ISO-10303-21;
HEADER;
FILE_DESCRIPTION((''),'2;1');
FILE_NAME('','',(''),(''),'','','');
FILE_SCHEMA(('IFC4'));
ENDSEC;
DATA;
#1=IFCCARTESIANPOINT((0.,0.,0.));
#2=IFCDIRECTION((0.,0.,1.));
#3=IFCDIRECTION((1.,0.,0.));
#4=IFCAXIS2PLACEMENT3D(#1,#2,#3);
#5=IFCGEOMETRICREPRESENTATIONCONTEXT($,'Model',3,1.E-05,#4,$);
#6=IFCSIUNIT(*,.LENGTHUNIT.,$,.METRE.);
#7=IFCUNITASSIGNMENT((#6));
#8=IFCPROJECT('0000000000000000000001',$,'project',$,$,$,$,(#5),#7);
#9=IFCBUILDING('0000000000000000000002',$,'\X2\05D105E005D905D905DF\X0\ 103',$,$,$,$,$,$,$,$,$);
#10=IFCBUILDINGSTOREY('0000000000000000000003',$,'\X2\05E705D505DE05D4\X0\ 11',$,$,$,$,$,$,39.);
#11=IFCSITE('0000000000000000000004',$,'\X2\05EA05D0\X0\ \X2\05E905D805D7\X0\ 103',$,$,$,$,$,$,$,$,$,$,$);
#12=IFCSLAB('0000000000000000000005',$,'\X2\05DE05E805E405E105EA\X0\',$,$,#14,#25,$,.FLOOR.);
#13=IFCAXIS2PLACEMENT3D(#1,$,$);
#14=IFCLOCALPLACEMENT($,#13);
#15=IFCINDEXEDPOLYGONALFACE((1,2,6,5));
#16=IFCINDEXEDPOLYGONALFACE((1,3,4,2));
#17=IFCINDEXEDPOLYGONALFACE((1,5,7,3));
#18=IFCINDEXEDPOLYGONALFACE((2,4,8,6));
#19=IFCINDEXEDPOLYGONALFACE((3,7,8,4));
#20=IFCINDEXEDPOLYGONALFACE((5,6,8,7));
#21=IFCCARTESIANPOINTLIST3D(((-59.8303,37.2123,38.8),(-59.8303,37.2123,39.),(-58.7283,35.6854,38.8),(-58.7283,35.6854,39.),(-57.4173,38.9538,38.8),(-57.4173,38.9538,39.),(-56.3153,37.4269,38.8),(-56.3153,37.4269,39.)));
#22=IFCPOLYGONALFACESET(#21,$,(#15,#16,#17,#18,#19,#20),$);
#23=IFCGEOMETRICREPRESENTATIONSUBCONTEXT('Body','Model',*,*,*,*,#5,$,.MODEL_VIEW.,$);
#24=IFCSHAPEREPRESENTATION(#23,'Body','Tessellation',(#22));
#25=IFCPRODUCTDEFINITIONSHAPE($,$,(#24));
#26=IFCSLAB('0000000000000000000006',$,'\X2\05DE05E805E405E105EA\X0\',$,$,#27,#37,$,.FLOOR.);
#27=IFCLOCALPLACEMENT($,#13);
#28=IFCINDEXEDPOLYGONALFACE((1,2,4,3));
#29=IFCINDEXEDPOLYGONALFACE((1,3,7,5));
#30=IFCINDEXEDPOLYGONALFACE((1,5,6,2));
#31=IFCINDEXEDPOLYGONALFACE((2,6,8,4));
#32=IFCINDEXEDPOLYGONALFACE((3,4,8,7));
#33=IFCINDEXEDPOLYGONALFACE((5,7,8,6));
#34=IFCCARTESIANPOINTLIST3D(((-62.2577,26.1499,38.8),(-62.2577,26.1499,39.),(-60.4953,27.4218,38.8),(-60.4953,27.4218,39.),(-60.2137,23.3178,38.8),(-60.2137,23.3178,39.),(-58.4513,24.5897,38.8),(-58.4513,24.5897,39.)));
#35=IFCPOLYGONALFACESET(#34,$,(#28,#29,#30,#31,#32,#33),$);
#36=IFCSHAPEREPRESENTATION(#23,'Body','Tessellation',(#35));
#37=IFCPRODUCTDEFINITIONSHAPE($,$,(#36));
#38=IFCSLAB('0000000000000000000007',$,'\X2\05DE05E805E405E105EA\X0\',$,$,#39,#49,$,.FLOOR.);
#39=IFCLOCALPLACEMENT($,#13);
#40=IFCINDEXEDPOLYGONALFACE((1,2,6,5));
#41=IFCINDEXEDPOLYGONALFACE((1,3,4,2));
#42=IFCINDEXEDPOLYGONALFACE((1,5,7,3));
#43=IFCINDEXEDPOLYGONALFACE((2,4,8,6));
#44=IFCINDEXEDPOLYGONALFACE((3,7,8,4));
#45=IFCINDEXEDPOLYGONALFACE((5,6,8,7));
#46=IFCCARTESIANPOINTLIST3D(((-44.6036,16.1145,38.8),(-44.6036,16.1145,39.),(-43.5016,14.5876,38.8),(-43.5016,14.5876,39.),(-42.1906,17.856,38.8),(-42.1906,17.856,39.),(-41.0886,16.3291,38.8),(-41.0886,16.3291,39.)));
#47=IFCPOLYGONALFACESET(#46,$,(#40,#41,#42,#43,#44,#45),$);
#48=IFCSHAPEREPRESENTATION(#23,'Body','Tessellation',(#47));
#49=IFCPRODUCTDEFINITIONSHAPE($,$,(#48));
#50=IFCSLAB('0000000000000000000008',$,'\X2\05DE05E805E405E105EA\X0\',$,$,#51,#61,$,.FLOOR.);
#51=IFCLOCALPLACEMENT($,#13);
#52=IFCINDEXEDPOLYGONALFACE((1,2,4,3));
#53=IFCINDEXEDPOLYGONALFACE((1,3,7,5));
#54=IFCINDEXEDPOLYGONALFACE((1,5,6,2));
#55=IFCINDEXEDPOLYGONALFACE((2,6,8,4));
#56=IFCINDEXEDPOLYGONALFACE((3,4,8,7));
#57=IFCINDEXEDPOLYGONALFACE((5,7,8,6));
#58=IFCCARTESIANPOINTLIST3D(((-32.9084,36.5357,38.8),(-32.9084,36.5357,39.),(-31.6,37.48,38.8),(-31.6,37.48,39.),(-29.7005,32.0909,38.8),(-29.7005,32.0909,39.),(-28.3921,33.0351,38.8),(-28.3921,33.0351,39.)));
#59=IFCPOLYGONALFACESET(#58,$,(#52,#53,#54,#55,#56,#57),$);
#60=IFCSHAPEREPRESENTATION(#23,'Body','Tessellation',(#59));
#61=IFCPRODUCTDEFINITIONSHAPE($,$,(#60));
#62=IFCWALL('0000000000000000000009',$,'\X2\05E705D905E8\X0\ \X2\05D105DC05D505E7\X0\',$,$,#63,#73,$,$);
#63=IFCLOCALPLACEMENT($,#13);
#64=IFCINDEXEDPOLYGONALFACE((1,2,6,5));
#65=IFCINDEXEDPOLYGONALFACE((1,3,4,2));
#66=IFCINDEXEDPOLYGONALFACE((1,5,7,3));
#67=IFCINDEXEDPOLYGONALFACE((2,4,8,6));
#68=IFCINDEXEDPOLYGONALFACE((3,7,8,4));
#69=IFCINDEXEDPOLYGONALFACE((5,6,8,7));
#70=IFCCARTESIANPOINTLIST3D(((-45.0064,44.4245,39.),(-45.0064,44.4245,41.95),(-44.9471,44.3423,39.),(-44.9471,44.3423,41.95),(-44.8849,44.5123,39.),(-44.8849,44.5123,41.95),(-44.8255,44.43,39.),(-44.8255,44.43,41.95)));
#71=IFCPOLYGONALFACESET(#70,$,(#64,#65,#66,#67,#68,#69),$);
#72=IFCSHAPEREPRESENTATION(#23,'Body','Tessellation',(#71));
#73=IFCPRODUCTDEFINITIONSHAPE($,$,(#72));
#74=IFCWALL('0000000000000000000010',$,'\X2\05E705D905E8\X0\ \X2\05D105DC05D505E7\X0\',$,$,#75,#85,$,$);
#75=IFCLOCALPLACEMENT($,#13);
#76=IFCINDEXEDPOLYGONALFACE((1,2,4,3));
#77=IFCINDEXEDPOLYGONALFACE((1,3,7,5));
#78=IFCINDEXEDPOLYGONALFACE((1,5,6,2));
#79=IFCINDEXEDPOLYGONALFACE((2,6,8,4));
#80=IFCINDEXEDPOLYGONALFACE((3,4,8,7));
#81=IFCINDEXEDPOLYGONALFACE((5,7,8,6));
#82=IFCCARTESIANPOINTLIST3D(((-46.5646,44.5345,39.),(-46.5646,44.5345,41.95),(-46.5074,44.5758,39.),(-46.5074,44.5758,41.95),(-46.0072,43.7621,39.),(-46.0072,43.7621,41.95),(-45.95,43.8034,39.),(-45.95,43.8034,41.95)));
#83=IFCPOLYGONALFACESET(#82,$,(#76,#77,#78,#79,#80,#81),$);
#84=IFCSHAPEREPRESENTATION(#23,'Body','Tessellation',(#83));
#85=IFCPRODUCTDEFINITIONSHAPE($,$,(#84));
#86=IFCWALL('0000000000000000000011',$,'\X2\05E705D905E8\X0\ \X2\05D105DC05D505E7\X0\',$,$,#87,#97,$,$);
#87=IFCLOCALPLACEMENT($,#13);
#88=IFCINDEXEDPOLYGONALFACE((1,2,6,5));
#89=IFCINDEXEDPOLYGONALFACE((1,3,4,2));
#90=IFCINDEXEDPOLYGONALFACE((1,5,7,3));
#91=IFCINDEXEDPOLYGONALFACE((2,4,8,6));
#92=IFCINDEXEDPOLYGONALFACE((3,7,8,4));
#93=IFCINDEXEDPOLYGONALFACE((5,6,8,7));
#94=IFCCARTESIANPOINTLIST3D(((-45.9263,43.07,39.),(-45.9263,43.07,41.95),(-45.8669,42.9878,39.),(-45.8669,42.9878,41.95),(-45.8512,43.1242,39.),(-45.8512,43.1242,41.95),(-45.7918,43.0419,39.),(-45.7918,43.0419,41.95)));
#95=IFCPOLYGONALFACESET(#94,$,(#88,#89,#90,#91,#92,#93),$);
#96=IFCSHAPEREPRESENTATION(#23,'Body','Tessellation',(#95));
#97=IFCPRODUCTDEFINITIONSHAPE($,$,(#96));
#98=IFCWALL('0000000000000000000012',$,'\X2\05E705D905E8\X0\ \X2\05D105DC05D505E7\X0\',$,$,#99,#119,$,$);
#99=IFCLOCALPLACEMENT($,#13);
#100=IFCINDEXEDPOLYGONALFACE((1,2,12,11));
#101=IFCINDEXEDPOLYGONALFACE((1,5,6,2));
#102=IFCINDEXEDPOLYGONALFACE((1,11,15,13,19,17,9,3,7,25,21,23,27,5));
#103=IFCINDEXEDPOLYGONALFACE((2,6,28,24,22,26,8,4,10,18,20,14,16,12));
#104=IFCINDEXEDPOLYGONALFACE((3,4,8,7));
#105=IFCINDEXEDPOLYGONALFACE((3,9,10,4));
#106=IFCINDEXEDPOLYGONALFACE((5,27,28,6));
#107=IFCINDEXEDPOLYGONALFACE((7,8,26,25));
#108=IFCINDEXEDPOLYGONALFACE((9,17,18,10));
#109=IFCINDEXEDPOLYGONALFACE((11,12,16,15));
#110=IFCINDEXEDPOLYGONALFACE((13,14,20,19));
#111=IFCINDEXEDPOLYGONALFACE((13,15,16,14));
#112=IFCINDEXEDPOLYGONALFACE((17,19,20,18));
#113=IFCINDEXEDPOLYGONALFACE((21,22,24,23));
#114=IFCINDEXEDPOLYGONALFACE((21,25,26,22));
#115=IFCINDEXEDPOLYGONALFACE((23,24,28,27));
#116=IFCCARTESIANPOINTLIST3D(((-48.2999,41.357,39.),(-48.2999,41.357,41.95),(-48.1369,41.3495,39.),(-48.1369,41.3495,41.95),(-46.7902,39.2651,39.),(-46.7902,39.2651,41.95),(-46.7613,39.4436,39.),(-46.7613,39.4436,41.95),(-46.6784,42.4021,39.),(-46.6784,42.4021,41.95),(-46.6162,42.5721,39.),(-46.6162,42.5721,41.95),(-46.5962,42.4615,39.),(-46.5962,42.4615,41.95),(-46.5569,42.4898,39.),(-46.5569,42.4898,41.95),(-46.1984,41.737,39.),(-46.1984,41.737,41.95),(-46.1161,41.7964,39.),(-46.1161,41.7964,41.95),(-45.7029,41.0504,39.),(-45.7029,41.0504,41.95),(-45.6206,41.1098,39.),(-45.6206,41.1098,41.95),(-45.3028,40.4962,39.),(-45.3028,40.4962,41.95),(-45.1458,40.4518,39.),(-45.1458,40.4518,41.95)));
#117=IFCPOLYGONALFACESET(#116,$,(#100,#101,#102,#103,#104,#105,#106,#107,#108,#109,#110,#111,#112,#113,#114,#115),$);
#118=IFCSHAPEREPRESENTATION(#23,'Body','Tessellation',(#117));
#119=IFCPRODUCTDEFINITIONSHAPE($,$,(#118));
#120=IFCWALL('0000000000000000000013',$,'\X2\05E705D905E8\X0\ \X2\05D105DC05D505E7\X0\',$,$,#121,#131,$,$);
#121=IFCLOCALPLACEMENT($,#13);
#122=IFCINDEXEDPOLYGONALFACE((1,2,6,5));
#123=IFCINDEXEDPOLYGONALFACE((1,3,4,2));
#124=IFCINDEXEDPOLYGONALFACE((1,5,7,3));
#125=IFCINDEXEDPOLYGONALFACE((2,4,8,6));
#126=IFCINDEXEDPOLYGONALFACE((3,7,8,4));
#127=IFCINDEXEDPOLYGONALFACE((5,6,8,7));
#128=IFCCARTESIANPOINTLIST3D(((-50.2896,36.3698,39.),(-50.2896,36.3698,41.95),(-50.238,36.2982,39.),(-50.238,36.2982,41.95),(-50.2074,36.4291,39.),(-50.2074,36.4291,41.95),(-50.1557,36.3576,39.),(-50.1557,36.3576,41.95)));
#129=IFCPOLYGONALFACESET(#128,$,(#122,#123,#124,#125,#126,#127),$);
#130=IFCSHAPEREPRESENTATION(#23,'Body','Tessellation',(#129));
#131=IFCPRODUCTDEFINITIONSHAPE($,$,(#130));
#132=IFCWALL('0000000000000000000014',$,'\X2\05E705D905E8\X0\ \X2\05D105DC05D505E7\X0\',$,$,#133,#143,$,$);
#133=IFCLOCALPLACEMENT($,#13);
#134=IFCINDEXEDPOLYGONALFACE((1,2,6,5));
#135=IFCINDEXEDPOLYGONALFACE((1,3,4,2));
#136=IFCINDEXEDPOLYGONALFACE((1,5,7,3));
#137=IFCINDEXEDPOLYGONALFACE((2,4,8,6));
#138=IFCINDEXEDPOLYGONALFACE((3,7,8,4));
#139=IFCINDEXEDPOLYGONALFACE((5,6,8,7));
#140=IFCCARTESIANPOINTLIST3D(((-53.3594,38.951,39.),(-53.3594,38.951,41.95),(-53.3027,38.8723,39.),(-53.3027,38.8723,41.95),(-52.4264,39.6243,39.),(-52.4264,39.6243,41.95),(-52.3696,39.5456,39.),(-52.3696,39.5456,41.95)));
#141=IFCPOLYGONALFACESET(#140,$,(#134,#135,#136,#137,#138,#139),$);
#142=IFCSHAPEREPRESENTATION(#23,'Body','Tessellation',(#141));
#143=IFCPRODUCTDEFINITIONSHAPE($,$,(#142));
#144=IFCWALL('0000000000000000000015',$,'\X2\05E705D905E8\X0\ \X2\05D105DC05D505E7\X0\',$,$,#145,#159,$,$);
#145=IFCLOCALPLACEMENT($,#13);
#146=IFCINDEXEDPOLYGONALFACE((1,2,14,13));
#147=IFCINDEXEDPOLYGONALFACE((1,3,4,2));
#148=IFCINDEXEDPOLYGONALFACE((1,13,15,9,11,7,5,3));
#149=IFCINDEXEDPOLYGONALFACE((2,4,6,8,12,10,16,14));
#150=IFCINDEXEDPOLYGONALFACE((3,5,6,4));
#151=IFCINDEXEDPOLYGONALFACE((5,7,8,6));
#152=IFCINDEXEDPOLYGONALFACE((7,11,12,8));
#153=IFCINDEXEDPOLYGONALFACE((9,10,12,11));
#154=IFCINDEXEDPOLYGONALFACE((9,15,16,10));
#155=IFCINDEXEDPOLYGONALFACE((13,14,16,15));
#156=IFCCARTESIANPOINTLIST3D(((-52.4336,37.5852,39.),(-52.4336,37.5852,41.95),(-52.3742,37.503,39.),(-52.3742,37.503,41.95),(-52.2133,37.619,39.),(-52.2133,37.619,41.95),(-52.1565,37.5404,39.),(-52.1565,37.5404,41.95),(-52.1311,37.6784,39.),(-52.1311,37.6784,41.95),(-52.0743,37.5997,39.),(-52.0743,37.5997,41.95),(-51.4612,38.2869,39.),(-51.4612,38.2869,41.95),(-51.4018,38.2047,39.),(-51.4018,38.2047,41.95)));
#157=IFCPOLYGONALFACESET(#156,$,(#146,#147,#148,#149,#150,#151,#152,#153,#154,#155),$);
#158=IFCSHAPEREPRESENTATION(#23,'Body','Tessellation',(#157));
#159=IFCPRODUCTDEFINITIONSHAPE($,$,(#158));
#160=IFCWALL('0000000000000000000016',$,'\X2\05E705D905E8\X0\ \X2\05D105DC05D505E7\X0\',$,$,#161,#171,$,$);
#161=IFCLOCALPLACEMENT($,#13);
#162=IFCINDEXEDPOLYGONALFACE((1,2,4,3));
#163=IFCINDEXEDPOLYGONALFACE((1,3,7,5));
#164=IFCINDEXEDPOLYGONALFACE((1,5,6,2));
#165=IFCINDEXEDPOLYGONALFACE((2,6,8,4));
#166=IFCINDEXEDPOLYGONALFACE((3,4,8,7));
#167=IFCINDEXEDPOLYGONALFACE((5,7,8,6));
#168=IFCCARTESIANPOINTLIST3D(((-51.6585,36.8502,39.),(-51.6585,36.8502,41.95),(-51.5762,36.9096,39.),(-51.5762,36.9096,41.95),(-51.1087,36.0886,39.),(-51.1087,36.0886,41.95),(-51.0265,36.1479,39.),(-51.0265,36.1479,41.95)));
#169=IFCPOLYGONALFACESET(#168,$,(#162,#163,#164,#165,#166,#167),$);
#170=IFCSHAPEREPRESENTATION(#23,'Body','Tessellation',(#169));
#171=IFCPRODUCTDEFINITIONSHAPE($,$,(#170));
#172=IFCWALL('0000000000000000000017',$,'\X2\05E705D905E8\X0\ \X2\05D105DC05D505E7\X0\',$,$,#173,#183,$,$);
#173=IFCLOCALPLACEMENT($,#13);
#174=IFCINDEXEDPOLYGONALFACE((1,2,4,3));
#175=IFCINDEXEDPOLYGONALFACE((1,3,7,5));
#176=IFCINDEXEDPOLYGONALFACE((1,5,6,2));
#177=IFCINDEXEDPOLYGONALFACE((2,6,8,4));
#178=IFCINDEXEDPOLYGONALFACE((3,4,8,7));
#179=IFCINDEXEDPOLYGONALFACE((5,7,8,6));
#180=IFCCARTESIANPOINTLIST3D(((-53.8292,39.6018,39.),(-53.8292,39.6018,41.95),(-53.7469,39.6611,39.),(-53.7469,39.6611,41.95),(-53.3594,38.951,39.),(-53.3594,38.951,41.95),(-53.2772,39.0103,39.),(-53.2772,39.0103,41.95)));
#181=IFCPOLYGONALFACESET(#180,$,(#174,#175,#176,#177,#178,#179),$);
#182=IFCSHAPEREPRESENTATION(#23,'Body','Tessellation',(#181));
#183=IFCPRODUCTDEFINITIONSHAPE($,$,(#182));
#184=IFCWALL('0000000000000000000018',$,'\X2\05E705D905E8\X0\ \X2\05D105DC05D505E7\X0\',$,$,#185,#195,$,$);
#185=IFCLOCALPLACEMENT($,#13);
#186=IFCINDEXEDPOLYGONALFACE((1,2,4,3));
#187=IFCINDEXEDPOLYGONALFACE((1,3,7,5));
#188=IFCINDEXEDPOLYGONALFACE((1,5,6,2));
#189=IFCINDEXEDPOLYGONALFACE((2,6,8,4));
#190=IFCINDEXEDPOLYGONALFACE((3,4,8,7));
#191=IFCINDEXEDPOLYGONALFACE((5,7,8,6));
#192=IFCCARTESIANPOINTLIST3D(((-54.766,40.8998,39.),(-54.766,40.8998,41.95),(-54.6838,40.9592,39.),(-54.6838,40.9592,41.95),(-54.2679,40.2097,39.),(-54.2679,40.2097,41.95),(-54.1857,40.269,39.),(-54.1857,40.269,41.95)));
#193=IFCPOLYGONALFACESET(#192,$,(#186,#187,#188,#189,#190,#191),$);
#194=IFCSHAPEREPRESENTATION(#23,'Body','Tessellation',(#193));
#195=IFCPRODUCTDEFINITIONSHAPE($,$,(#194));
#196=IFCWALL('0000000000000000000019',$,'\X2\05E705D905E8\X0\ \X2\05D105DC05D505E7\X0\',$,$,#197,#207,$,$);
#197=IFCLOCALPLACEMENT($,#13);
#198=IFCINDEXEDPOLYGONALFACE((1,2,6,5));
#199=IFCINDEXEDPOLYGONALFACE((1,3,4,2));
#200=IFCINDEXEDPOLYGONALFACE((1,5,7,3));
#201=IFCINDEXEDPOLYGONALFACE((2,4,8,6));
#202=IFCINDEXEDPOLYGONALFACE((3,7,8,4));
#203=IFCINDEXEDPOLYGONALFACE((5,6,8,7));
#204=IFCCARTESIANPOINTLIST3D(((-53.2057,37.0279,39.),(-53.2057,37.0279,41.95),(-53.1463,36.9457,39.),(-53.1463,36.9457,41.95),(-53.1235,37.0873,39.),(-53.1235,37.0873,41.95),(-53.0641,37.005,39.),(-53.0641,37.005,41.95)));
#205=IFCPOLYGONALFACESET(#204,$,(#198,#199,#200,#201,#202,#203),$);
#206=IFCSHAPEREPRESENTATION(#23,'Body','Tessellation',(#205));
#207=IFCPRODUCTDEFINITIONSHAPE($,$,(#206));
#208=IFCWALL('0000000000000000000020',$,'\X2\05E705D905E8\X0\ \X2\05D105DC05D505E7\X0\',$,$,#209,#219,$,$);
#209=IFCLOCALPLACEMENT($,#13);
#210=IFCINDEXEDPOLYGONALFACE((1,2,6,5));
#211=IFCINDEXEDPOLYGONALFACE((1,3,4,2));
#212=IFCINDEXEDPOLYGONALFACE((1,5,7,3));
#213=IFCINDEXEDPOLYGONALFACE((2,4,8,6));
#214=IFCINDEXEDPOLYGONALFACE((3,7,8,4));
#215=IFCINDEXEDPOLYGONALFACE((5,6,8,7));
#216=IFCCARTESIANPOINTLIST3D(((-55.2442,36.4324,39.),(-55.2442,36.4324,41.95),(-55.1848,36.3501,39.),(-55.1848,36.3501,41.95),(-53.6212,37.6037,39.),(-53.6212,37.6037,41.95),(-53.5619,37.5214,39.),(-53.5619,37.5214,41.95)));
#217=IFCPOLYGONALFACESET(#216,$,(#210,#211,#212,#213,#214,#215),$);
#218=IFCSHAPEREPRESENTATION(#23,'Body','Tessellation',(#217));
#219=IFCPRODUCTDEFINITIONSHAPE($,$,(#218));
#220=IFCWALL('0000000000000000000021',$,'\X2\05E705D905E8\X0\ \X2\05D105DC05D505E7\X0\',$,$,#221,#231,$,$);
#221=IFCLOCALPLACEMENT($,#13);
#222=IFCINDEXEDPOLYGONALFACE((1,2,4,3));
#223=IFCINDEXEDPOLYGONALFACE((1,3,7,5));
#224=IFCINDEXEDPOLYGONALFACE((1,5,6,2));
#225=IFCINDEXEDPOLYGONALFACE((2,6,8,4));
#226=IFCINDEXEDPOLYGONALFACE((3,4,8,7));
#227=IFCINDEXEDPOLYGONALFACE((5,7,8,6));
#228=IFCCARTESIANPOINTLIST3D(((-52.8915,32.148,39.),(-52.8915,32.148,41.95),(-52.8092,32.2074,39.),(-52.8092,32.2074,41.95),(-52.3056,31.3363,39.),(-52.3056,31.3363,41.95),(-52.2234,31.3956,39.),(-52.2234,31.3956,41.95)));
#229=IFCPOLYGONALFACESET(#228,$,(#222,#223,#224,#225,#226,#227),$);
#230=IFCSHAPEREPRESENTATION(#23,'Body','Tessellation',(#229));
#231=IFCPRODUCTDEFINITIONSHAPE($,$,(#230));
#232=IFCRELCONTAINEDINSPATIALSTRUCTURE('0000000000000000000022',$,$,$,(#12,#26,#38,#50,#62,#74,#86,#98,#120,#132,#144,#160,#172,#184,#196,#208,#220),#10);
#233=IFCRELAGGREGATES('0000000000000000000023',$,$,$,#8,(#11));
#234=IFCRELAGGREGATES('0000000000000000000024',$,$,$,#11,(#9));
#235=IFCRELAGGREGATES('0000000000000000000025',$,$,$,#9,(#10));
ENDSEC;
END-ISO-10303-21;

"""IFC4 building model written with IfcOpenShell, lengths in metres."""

from ifc_helpers import new_model, si_unit, frame, origin_with_axes, context, subcontext, project, spatial, polyline, outline, extrude, element, save


model = new_model("IFC4")

# Units and contexts
model_context = context("Model", 3, precision=1e-05, world=origin_with_axes())
body_context = subcontext(model_context, "Body", "Model", "MODEL_VIEW")
ifc_project = project(units=[si_unit("LENGTHUNIT", "METRE")], contexts=[model_context])

# Site, building, storey
site = spatial("IfcSite", under=ifc_project, Name="תא שטח 103")
building = spatial("IfcBuilding", under=site, Name="בניין 103")
storey = spatial("IfcBuildingStorey", under=building, Name="קומה 11", Elevation=39.0)

# Slabs
element("IfcSlab", 1, inside=storey, Name="מרפסת", PredefinedType="FLOOR", context=body_context, shape_type="SweptSolid", body=[
    extrude(outline(polyline([(-56.3153, 37.4269), (-57.4173, 38.9538), (-59.8303, 37.2123), (-58.7283, 35.6854), (-56.3153, 37.4269)])), frame((0.0, 0.0, 38.8)), (0.0, 0.0, 1.0), 0.2),
])
element("IfcSlab", 2, inside=storey, Name="מרפסת", PredefinedType="FLOOR", context=body_context, shape_type="SweptSolid", body=[
    extrude(outline(polyline([(-58.4513, 24.5897), (-60.4953, 27.4218), (-62.2577, 26.1499), (-60.2137, 23.3178), (-58.4513, 24.5897)])), frame((0.0, 0.0, 38.8)), (0.0, 0.0, 1.0), 0.2),
])
element("IfcSlab", 3, inside=storey, Name="מרפסת", PredefinedType="FLOOR", context=body_context, shape_type="SweptSolid", body=[
    extrude(outline(polyline([(-41.0886, 16.3291), (-42.1906, 17.856), (-44.6036, 16.1145), (-43.5016, 14.5876), (-41.0886, 16.3291)])), frame((0.0, 0.0, 38.8)), (0.0, 0.0, 1.0), 0.2),
])
element("IfcSlab", 4, inside=storey, Name="מרפסת", PredefinedType="FLOOR", context=body_context, shape_type="SweptSolid", body=[
    extrude(outline(polyline([(-28.3921, 33.0351), (-31.6, 37.48), (-32.9084, 36.5357), (-29.7005, 32.0909), (-28.3921, 33.0351)])), frame((0.0, 0.0, 38.8)), (0.0, 0.0, 1.0), 0.2),
])

# Walls
element("IfcWall", 5, inside=storey, Name="קיר בלוק", context=body_context, shape_type="SweptSolid", body=[
    extrude(outline(polyline([(-44.8255, 44.43), (-44.9471, 44.3423), (-45.0064, 44.4245), (-44.8849, 44.5123), (-44.8255, 44.43)])), frame((0.0, 0.0, 39.0)), (0.0, 0.0, 1.0), 2.95),
])
element("IfcWall", 6, inside=storey, Name="קיר בלוק", context=body_context, shape_type="SweptSolid", body=[
    extrude(outline(polyline([(-45.95, 43.8034), (-46.0072, 43.7621), (-46.5646, 44.5345), (-46.5074, 44.5758), (-45.95, 43.8034)])), frame((0.0, 0.0, 39.0)), (0.0, 0.0, 1.0), 2.95),
])
element("IfcWall", 7, inside=storey, Name="קיר בלוק", context=body_context, shape_type="SweptSolid", body=[
    extrude(outline(polyline([(-45.8669, 42.9878), (-45.9263, 43.07), (-45.8512, 43.1242), (-45.7918, 43.0419), (-45.8669, 42.9878)])), frame((0.0, 0.0, 39.0)), (0.0, 0.0, 1.0), 2.95),
])
element("IfcWall", 8, inside=storey, Name="קיר בלוק", context=body_context, shape_type="SweptSolid", body=[
    extrude(outline(polyline([(-46.7902, 39.2651), (-48.2999, 41.357), (-46.6162, 42.5721), (-46.5569, 42.4898), (-46.5962, 42.4615), (-46.1161, 41.7964), (-46.1984, 41.737), (-46.6784, 42.4021), (-48.1369, 41.3495), (-46.7613, 39.4436), (-45.3028, 40.4962), (-45.7029, 41.0504), (-45.6206, 41.1098), (-45.1458, 40.4518), (-46.7902, 39.2651)])), frame((0.0, 0.0, 39.0)), (0.0, 0.0, 1.0), 2.95),
])
element("IfcWall", 9, inside=storey, Name="קיר בלוק", context=body_context, shape_type="SweptSolid", body=[
    extrude(outline(polyline([(-50.1557, 36.3576), (-50.238, 36.2982), (-50.2896, 36.3698), (-50.2074, 36.4291), (-50.1557, 36.3576)])), frame((0.0, 0.0, 39.0)), (0.0, 0.0, 1.0), 2.95),
])
element("IfcWall", 10, inside=storey, Name="קיר בלוק", context=body_context, shape_type="SweptSolid", body=[
    extrude(outline(polyline([(-53.3594, 38.951), (-52.4264, 39.6243), (-52.3696, 39.5456), (-53.3027, 38.8723), (-53.3594, 38.951)])), frame((0.0, 0.0, 39.0)), (0.0, 0.0, 1.0), 2.95),
])
element("IfcWall", 11, inside=storey, Name="קיר בלוק", context=body_context, shape_type="SweptSolid", body=[
    extrude(outline(polyline([(-52.2133, 37.619), (-52.3742, 37.503), (-52.4336, 37.5852), (-51.4612, 38.2869), (-51.4018, 38.2047), (-52.1311, 37.6784), (-52.0743, 37.5997), (-52.1565, 37.5404), (-52.2133, 37.619)])), frame((0.0, 0.0, 39.0)), (0.0, 0.0, 1.0), 2.95),
])
element("IfcWall", 12, inside=storey, Name="קיר בלוק", context=body_context, shape_type="SweptSolid", body=[
    extrude(outline(polyline([(-51.1087, 36.0886), (-51.6585, 36.8502), (-51.5762, 36.9096), (-51.0265, 36.1479), (-51.1087, 36.0886)])), frame((0.0, 0.0, 39.0)), (0.0, 0.0, 1.0), 2.95),
])
element("IfcWall", 13, inside=storey, Name="קיר בלוק", context=body_context, shape_type="SweptSolid", body=[
    extrude(outline(polyline([(-53.2772, 39.0103), (-53.3594, 38.951), (-53.8292, 39.6018), (-53.7469, 39.6611), (-53.2772, 39.0103)])), frame((0.0, 0.0, 39.0)), (0.0, 0.0, 1.0), 2.95),
])
element("IfcWall", 14, inside=storey, Name="קיר בלוק", context=body_context, shape_type="SweptSolid", body=[
    extrude(outline(polyline([(-54.1857, 40.269), (-54.2679, 40.2097), (-54.766, 40.8998), (-54.6838, 40.9592), (-54.1857, 40.269)])), frame((0.0, 0.0, 39.0)), (0.0, 0.0, 1.0), 2.95),
])
element("IfcWall", 15, inside=storey, Name="קיר בלוק", context=body_context, shape_type="SweptSolid", body=[
    extrude(outline(polyline([(-53.0641, 37.005), (-53.1463, 36.9457), (-53.2057, 37.0279), (-53.1235, 37.0873), (-53.0641, 37.005)])), frame((0.0, 0.0, 39.0)), (0.0, 0.0, 1.0), 2.95),
])
element("IfcWall", 16, inside=storey, Name="קיר בלוק", context=body_context, shape_type="SweptSolid", body=[
    extrude(outline(polyline([(-53.6212, 37.6037), (-53.5619, 37.5214), (-55.1848, 36.3501), (-55.2442, 36.4324), (-53.6212, 37.6037)])), frame((0.0, 0.0, 39.0)), (0.0, 0.0, 1.0), 2.95),
])
element("IfcWall", 17, inside=storey, Name="קיר בלוק", context=body_context, shape_type="SweptSolid", body=[
    extrude(outline(polyline([(-52.8915, 32.148), (-52.8092, 32.2074), (-52.2234, 31.3956), (-52.3056, 31.3363), (-52.8915, 32.148)])), frame((0.0, 0.0, 39.0)), (0.0, 0.0, 1.0), 2.95),
])

save(model, "model.ifc")
